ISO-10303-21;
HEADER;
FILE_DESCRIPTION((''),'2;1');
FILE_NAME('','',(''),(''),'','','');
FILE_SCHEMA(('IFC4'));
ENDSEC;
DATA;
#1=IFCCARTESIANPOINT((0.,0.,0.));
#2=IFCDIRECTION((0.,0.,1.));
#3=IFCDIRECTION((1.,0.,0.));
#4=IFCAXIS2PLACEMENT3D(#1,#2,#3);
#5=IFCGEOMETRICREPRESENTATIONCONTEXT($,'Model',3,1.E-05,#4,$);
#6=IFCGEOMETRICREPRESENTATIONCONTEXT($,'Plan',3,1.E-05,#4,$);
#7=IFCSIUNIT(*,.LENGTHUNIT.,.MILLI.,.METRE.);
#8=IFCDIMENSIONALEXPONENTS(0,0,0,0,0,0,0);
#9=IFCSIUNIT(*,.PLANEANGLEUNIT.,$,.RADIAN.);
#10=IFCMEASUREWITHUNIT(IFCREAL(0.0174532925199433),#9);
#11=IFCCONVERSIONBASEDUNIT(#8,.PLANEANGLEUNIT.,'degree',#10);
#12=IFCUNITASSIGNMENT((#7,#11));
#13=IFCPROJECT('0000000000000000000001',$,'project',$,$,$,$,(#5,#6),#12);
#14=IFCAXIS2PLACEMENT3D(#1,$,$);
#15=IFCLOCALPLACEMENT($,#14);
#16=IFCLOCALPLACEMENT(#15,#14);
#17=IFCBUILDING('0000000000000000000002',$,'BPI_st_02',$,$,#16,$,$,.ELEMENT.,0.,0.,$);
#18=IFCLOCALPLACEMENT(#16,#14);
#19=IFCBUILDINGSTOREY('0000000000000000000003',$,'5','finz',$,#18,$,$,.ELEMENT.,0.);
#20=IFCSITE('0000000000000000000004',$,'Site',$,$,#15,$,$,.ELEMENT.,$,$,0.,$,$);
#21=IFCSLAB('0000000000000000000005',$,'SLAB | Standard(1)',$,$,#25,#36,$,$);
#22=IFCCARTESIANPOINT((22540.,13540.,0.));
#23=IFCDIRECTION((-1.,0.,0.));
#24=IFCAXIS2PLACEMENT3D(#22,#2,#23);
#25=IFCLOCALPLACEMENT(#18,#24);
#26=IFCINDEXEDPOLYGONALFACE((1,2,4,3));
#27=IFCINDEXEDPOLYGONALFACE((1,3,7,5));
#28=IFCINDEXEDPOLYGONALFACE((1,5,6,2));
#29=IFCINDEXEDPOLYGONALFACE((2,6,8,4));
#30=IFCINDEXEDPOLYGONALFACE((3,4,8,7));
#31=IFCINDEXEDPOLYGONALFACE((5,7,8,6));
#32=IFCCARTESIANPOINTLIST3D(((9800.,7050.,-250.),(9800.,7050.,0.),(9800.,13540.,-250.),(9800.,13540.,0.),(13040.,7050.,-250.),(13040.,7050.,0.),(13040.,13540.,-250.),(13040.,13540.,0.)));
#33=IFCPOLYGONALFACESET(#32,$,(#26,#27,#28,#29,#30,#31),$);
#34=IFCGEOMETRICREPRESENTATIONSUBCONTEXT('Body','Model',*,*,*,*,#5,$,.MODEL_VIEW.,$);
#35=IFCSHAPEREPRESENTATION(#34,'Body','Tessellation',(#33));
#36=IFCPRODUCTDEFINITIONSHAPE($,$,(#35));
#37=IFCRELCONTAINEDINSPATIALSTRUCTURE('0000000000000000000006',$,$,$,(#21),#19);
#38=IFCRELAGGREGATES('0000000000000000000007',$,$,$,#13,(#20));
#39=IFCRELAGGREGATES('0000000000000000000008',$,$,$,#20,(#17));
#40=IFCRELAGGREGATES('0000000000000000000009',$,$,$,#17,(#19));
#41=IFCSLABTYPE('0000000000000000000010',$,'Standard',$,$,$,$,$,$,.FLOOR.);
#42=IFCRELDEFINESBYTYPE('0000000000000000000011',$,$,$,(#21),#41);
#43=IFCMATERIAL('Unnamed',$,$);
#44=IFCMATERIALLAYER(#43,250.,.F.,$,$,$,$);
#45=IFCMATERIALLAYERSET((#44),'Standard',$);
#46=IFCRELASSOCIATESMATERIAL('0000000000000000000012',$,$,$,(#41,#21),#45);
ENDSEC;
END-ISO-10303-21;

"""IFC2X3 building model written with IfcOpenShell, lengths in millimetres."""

from ifc_helpers import new_model, entity, si_unit, converted_unit, frame, frame_2d, origin, origin_with_axes, place, context, subcontext, project, spatial, rectangle, extrude, material, layer, layer_set, layer_usage, type_object, element, save


model = new_model("IFC2X3")

# Units and contexts
model_context = context("Model", 3, precision=1e-05, world=origin_with_axes())
plan_context = context("Plan", 3, precision=1e-05, world=origin_with_axes())
body_context = subcontext(model_context, "Body", "Model", "MODEL_VIEW")
ifc_project = project(units=[si_unit("LENGTHUNIT", "METRE", prefix="MILLI"), converted_unit("PLANEANGLEUNIT", "degree", entity("IfcReal", 0.0174532925199433), si_unit("PLANEANGLEUNIT", "RADIAN"), dimensions=[0, 0, 0, 0, 0, 0, 0])], contexts=[model_context, plan_context])

# Site, building, storey
site_placement = place(None, origin())
site = spatial("IfcSite", under=ifc_project, at=site_placement, Name="Site", CompositionType="ELEMENT", RefElevation=0.0)
building_placement = place(site_placement, origin())
building = spatial("IfcBuilding", under=site, at=building_placement, Name="BPI_st_02", CompositionType="ELEMENT", ElevationOfRefHeight=0.0, ElevationOfTerrain=0.0)
storey_placement = place(building_placement, origin())
storey = spatial("IfcBuildingStorey", under=building, at=storey_placement, Name="5", Description="finz", CompositionType="ELEMENT", Elevation=0.0)

# Slab
ifc_material = material(Name="Unnamed")
ifc_layer_1 = layer(ifc_material, 250.0, ventilated=False)
ifc_layer_set_1 = layer_set([ifc_layer_1], Name="Standard")
ifc_layer_usage_1 = layer_usage(ifc_layer_set_1, "AXIS3", "POSITIVE", 0.0)
slab_type = type_object("IfcSlabType", Name="Standard", PredefinedType="FLOOR", material=ifc_layer_set_1)
slab_placement = place(storey_placement, frame((22540.0, 13540.0, 0.0), z_axis=(0.0, 0.0, 1.0), x_axis=(-1.0, 0.0, 0.0)))
element("IfcSlab", 1, at=slab_placement, inside=storey, type_object=slab_type, material=ifc_layer_usage_1, Name="SLAB | Standard(1)", context=body_context, shape_type="SweptSolid", body=[
    extrude(rectangle(XDim=3240.0, YDim=6490.0, at=frame_2d((11420.0, 10295.0), x_axis=(1.0, 0.0))), frame((0.0, 0.0, -250.0)), (0.0, 0.0, 1.0), 250.0),
])

save(model, "model.ifc")
